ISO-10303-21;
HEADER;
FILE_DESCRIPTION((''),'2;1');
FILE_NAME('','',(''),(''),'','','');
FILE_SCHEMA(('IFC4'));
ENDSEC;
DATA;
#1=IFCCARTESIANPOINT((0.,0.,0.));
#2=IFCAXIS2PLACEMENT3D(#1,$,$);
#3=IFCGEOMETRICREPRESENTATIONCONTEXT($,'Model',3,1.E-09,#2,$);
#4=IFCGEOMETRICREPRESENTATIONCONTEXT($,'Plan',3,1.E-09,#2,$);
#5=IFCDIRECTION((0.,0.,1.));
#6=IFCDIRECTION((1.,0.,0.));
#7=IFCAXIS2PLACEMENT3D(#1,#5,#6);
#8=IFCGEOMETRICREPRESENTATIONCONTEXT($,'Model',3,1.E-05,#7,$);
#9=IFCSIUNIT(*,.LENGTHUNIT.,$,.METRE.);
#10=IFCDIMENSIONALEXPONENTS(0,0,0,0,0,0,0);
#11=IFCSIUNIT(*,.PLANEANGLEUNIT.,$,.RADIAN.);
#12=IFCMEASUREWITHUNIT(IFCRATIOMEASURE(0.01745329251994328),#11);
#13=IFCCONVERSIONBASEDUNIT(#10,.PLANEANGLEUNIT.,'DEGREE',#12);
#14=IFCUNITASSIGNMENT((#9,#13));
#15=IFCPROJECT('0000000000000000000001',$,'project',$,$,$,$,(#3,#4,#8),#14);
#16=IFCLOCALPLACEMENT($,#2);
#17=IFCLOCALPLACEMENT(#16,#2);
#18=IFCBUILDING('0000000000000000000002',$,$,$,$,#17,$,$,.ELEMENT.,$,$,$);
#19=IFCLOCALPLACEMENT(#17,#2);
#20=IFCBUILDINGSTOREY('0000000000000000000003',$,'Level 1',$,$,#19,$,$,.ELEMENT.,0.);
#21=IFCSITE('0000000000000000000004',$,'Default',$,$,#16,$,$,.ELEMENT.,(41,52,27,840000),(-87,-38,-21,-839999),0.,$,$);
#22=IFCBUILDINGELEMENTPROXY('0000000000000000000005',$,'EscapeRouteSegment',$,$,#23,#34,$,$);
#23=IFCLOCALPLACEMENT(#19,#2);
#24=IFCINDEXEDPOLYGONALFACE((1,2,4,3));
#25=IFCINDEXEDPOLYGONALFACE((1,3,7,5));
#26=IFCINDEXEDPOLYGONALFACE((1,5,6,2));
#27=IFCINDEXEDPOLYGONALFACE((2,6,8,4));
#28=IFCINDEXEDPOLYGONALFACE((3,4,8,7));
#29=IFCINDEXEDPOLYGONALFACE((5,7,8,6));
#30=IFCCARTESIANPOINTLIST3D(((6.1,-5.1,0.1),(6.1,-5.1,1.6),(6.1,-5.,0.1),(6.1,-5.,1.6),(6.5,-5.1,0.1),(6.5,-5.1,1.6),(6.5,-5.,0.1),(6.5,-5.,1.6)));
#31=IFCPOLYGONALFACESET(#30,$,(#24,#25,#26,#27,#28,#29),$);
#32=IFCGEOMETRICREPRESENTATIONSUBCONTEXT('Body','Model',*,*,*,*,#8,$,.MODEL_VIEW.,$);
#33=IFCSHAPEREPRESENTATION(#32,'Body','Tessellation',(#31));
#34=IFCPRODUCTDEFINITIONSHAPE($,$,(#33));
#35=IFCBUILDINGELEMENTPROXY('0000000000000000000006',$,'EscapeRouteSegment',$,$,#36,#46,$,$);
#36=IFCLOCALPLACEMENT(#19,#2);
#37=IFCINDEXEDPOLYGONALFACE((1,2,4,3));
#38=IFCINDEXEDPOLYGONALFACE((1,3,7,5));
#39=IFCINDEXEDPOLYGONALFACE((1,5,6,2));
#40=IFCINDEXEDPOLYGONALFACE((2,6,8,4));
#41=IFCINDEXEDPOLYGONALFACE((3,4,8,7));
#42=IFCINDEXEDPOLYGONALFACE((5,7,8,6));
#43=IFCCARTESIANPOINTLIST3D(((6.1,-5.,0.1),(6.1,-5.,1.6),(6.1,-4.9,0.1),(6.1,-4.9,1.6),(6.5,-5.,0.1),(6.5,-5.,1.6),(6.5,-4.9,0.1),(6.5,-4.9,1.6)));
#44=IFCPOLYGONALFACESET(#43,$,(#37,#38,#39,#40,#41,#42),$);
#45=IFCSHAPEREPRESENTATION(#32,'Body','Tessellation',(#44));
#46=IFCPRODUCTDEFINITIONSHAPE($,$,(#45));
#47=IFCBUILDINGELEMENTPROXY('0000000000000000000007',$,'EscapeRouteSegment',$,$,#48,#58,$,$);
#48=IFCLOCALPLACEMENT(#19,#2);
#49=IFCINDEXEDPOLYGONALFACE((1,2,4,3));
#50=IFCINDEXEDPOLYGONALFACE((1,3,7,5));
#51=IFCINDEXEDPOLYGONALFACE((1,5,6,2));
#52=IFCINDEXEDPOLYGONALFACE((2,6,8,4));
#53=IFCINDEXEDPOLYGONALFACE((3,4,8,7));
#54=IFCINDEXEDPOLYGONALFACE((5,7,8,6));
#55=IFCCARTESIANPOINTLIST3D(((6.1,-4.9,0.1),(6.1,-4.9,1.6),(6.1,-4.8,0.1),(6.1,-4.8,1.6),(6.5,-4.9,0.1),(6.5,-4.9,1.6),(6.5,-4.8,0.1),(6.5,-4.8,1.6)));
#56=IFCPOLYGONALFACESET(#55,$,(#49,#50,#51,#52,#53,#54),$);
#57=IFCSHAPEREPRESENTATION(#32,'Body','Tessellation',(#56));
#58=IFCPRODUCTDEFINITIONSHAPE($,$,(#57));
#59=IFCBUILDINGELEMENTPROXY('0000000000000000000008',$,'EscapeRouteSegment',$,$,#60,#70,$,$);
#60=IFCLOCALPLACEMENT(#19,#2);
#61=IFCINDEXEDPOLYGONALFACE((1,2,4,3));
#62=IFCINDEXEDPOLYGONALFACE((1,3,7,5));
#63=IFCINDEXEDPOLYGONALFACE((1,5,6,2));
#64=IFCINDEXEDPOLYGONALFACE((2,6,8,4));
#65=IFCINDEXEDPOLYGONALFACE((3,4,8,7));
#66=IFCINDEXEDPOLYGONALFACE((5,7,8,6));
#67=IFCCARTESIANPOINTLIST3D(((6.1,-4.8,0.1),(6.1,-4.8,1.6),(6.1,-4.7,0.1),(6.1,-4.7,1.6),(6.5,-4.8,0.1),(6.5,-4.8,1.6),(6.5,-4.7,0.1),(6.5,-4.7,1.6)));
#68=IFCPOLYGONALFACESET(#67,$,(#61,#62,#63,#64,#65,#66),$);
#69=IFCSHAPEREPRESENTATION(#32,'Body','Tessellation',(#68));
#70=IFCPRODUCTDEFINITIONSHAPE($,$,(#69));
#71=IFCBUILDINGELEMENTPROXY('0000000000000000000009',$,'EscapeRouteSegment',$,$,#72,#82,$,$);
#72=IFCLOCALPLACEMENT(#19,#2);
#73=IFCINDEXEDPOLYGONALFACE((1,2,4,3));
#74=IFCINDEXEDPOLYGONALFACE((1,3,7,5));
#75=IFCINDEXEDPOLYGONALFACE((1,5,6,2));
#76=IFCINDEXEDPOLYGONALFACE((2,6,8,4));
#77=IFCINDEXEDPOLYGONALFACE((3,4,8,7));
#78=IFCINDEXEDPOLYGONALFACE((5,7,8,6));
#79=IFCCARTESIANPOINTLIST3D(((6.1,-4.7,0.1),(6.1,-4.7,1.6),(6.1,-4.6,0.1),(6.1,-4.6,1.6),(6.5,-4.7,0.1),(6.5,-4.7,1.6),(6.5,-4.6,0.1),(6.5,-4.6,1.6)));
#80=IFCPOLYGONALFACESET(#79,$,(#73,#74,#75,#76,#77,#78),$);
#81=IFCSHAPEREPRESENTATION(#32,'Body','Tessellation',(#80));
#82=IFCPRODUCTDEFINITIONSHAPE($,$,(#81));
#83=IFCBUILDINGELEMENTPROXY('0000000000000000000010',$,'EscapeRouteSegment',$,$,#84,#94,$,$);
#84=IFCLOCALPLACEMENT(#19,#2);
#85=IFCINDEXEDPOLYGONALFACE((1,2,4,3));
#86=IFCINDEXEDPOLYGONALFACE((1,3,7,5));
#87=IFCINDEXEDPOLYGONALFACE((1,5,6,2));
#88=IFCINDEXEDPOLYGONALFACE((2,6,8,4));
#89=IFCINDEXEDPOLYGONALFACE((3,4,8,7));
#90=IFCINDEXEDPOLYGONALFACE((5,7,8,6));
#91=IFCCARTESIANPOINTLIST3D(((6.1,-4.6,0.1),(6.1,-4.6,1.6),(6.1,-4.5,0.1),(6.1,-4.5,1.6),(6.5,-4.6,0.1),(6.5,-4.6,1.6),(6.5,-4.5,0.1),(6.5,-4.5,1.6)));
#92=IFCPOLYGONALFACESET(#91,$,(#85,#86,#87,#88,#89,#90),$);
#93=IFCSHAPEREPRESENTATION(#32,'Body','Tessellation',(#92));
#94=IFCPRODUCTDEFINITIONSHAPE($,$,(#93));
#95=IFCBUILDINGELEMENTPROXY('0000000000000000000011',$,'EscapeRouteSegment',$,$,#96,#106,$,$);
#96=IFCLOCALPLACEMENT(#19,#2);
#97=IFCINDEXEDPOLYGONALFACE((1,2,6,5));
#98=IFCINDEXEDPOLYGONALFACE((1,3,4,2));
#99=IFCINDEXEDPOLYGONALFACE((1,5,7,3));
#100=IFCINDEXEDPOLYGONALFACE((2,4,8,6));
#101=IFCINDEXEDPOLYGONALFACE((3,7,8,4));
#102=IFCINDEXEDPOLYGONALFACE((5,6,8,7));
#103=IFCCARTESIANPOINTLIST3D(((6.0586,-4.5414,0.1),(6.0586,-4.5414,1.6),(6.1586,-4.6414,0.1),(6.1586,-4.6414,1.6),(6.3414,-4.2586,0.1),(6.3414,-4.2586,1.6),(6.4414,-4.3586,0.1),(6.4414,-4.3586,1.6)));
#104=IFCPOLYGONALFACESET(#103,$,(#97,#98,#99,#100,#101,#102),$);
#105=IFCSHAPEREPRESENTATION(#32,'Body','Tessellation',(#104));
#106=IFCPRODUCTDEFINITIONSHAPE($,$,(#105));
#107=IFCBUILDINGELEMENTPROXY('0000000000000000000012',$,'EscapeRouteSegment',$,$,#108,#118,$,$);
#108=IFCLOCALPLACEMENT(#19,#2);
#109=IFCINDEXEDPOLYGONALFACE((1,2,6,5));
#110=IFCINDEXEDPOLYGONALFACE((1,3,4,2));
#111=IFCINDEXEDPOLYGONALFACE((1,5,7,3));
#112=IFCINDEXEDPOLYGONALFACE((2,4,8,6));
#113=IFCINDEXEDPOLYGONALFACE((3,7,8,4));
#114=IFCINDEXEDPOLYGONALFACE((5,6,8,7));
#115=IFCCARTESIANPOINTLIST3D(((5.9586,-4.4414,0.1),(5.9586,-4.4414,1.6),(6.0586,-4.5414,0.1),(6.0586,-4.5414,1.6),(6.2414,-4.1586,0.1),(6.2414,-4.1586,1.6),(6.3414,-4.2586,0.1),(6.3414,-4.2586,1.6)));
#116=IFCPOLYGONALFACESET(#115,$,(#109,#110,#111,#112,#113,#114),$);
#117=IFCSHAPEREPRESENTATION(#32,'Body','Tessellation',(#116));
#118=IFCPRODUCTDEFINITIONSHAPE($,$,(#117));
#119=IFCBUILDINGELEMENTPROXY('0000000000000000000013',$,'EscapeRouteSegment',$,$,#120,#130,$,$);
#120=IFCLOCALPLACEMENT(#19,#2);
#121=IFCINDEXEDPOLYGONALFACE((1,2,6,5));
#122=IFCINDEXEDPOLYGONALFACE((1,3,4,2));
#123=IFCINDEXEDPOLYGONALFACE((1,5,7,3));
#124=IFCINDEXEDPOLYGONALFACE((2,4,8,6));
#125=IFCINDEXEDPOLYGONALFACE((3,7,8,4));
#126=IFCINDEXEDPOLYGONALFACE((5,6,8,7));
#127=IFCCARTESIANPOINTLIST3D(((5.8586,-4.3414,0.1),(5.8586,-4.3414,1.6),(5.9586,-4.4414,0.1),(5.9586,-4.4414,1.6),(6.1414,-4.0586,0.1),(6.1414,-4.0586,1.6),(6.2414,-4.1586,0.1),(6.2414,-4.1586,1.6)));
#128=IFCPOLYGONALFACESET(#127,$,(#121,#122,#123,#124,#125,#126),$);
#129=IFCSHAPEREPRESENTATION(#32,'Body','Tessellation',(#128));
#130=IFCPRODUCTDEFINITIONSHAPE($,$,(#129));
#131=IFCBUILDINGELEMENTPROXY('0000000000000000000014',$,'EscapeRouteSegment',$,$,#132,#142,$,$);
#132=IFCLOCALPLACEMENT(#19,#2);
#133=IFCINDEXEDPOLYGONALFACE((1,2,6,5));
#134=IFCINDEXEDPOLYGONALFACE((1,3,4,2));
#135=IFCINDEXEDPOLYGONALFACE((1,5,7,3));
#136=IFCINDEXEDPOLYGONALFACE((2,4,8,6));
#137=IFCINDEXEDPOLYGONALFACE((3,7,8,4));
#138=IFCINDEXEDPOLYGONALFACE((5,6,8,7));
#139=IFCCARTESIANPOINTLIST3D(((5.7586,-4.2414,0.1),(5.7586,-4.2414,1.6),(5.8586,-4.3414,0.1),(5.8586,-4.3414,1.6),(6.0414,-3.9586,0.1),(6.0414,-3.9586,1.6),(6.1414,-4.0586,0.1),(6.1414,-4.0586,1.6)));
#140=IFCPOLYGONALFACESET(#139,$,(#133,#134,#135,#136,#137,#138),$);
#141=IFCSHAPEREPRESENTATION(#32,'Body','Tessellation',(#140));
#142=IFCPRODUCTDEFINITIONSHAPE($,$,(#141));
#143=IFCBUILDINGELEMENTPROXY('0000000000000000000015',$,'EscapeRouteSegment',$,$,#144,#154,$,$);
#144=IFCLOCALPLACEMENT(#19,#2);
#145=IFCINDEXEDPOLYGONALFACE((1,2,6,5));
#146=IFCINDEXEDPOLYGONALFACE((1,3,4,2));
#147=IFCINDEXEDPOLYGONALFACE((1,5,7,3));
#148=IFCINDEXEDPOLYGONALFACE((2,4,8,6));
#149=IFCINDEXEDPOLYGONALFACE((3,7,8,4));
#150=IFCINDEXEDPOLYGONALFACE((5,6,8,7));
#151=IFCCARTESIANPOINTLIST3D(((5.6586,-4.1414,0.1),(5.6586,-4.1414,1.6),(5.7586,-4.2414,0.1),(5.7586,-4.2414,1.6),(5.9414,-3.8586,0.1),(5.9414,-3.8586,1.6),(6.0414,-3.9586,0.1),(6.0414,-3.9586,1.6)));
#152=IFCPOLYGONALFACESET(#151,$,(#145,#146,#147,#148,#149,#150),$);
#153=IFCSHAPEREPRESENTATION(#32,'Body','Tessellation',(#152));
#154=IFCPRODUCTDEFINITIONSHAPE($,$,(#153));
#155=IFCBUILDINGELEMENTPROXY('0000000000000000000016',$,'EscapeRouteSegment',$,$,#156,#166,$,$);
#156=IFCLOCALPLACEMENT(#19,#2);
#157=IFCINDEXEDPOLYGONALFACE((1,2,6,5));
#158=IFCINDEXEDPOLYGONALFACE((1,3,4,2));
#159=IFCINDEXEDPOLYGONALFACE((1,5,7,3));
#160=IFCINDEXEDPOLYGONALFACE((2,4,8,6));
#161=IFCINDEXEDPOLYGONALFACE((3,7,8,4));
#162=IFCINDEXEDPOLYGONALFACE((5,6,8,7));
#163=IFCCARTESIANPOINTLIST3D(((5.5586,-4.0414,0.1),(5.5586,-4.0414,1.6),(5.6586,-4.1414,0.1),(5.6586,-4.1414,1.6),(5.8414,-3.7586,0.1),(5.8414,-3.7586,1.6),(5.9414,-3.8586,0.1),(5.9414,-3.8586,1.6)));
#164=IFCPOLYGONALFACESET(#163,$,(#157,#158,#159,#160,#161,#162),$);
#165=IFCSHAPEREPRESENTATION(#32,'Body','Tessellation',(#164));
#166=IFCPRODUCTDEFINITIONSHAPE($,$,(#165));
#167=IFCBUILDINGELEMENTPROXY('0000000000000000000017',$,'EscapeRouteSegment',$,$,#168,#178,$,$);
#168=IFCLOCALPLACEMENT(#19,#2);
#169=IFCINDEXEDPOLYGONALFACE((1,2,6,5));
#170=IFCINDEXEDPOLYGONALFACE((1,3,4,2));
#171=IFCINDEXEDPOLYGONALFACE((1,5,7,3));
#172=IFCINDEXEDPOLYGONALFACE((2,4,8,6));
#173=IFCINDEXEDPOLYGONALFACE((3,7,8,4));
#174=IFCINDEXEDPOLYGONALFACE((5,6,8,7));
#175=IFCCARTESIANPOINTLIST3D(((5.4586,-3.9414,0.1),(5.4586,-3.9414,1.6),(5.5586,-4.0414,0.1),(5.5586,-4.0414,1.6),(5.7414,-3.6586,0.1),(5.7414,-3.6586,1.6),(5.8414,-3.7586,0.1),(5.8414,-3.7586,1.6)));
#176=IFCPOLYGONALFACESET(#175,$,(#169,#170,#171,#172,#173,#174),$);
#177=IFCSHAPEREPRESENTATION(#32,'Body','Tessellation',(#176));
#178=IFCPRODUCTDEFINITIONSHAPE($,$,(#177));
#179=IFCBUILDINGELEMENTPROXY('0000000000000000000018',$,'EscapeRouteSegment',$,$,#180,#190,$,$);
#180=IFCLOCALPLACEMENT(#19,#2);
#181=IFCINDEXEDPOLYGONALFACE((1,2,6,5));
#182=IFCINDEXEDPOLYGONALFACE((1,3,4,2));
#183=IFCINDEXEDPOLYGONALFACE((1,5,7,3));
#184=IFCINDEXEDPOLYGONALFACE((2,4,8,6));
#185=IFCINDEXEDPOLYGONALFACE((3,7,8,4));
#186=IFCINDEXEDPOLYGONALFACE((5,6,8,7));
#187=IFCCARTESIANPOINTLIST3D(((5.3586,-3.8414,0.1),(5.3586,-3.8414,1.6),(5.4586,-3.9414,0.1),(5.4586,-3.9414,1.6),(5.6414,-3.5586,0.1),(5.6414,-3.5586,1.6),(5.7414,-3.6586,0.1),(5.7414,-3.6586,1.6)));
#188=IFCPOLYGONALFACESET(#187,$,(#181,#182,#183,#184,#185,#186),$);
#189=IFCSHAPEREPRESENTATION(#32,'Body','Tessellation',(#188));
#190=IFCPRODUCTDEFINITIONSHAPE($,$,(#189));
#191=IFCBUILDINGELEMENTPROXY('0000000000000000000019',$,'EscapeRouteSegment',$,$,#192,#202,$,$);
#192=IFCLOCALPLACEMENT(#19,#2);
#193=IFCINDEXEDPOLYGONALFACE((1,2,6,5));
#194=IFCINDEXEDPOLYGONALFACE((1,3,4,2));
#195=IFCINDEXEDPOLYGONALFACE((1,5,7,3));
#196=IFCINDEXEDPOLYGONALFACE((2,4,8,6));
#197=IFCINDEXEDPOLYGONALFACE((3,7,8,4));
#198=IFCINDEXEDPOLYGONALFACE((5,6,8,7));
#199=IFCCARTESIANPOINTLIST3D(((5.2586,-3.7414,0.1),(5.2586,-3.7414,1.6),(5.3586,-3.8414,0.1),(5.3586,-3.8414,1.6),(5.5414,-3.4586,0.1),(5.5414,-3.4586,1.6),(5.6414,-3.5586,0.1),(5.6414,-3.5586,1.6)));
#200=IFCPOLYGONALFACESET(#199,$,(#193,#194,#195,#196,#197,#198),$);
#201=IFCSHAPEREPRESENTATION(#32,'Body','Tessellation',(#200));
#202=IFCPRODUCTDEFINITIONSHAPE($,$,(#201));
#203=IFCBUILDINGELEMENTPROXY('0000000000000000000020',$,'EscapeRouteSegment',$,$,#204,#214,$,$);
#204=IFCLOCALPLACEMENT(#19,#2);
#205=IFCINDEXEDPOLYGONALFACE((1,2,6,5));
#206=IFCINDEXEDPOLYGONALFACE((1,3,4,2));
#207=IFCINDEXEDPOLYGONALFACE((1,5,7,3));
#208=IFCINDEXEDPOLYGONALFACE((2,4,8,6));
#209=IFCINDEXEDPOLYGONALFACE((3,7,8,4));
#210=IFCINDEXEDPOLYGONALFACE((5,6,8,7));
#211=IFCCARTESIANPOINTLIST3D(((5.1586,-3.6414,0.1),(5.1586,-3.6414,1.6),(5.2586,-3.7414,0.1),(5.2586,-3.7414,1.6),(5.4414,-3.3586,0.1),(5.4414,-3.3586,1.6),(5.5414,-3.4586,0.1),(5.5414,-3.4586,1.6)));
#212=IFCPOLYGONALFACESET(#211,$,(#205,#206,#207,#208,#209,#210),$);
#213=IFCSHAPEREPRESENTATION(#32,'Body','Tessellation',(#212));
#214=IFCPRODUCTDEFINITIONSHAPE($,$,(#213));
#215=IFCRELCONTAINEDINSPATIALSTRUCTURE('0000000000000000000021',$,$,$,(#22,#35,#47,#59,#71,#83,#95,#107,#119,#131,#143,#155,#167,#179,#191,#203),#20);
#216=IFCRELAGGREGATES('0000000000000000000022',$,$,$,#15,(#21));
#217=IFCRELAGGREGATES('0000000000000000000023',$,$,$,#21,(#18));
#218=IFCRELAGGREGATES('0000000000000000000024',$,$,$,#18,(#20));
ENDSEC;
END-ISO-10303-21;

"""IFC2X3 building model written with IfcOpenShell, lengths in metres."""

from ifc_helpers import new_model, entity, si_unit, converted_unit, frame, origin, origin_with_axes, place, context, subcontext, project, spatial, polyline, outline, extrude, element, save


model = new_model("IFC2X3")

# Units and contexts
model_context_1 = context("Model", 3, precision=1e-09, world=origin())
plan_context = context("Plan", 3, precision=1e-09, world=origin())
model_context_2 = context("Model", 3, precision=1e-05, world=origin_with_axes())
body_context = subcontext(model_context_2, "Body", "Model", "MODEL_VIEW")
ifc_project = project(units=[si_unit("LENGTHUNIT", "METRE"), converted_unit("PLANEANGLEUNIT", "DEGREE", entity("IfcRatioMeasure", 0.01745329251994328), si_unit("PLANEANGLEUNIT", "RADIAN"), dimensions=[0, 0, 0, 0, 0, 0, 0])], contexts=[model_context_1, plan_context, model_context_2])

# Site, building, storey
site_placement = place(None, origin())
site = spatial("IfcSite", under=ifc_project, at=site_placement, Name="Default", CompositionType="ELEMENT", RefLatitude=(41, 52, 27, 840000), RefLongitude=(-87, -38, -21, -839999), RefElevation=0.0)
building_placement = place(site_placement, origin())
building = spatial("IfcBuilding", under=site, at=building_placement, CompositionType="ELEMENT")
storey_placement = place(building_placement, origin())
storey = spatial("IfcBuildingStorey", under=building, at=storey_placement, Name="Level 1", CompositionType="ELEMENT", Elevation=0.0)

# Building element proxies
for number, where, z_axis, x_axis, name in (
    (1, (6.3, -5.1, 0.1), (0.0, 0.0, 1.0), (0.0, 1.0, 0.0), "EscapeRouteSegment"),
    (2, (6.3, -5.0, 0.1), (0.0, 0.0, 1.0), (0.0, 1.0, 0.0), "EscapeRouteSegment"),
    (3, (6.3, -4.9, 0.1), (0.0, 0.0, 1.0), (0.0, 1.0, 0.0), "EscapeRouteSegment"),
):
    element("IfcBuildingElementProxy", number, at=place(storey_placement, frame(where, z_axis=z_axis, x_axis=x_axis)), inside=storey, Name=name, context=body_context, shape_type="SweptSolid", body=[
        extrude(outline(polyline([(0.0, -0.2), (0.0, 0.2), (0.1, 0.2), (0.1, -0.2), (0.0, -0.2)])), origin_with_axes(), (0.0, 0.0, 1.0), 1.5),
    ])
proxy_1_placement = place(storey_placement, frame((6.3, -4.8, 0.1), z_axis=(0.0, 0.0, 1.0), x_axis=(0.0, 1.0, 0.0)))
element("IfcBuildingElementProxy", 4, at=proxy_1_placement, inside=storey, Name="EscapeRouteSegment", context=body_context, shape_type="SweptSolid", body=[
    extrude(outline(polyline([(0.0, -0.2), (0.0, 0.2), (0.1, 0.2), (0.1, -0.2), (0.0, -0.2)])), origin_with_axes(), (0.0, 0.0, 1.0), 1.5),
])
for number, where, z_axis, x_axis, name in (
    (5, (6.3, -4.7, 0.1), (0.0, 0.0, 1.0), (0.0, 1.0, 0.0), "EscapeRouteSegment"),
    (6, (6.3, -4.6, 0.1), (0.0, 0.0, 1.0), (0.0, 1.0, 0.0), "EscapeRouteSegment"),
):
    element("IfcBuildingElementProxy", number, at=place(storey_placement, frame(where, z_axis=z_axis, x_axis=x_axis)), inside=storey, Name=name, context=body_context, shape_type="SweptSolid", body=[
        extrude(outline(polyline([(0.0, -0.2), (0.0, 0.2), (0.1, 0.2), (0.1, -0.2), (0.0, -0.2)])), origin_with_axes(), (0.0, 0.0, 1.0), 1.5),
    ])
proxy_2_placement = place(storey_placement, frame((6.3, -4.5, 0.1), z_axis=(0.0, 0.0, 1.0), x_axis=(-0.707108, 0.707105, 0.0)))
element("IfcBuildingElementProxy", 7, at=proxy_2_placement, inside=storey, Name="EscapeRouteSegment", context=body_context, shape_type="SweptSolid", body=[
    extrude(outline(polyline([(0.0, -0.2), (0.0, 0.2), (0.1414, 0.2), (0.1414, -0.2), (0.0, -0.2)])), origin_with_axes(), (0.0, 0.0, 1.0), 1.5),
])
proxy_3_placement = place(storey_placement, frame((6.2, -4.4, 0.1), z_axis=(0.0, 0.0, 1.0), x_axis=(-0.707107, 0.707107, 0.0)))
element("IfcBuildingElementProxy", 8, at=proxy_3_placement, inside=storey, Name="EscapeRouteSegment", context=body_context, shape_type="SweptSolid", body=[
    extrude(outline(polyline([(0.0, -0.2), (0.0, 0.2), (0.1414, 0.2), (0.1414, -0.2), (0.0, -0.2)])), origin_with_axes(), (0.0, 0.0, 1.0), 1.5),
])
proxy_4_placement = place(storey_placement, frame((6.1, -4.3, 0.1), z_axis=(0.0, 0.0, 1.0), x_axis=(-0.707105, 0.707108, 0.0)))
element("IfcBuildingElementProxy", 9, at=proxy_4_placement, inside=storey, Name="EscapeRouteSegment", context=body_context, shape_type="SweptSolid", body=[
    extrude(outline(polyline([(0.0, -0.2), (0.0, 0.2), (0.1414, 0.2), (0.1414, -0.2), (0.0, -0.2)])), origin_with_axes(), (0.0, 0.0, 1.0), 1.5),
])
for number, where, z_axis, x_axis, name in (
    (10, (6.0, -4.2, 0.1), (0.0, 0.0, 1.0), (-0.707107, 0.707107, 0.0), "EscapeRouteSegment"),
    (11, (5.9, -4.1, 0.1), (0.0, 0.0, 1.0), (-0.707107, 0.707107, 0.0), "EscapeRouteSegment"),
):
    element("IfcBuildingElementProxy", number, at=place(storey_placement, frame(where, z_axis=z_axis, x_axis=x_axis)), inside=storey, Name=name, context=body_context, shape_type="SweptSolid", body=[
        extrude(outline(polyline([(0.0, -0.2), (0.0, 0.2), (0.1414, 0.2), (0.1414, -0.2), (0.0, -0.2)])), origin_with_axes(), (0.0, 0.0, 1.0), 1.5),
    ])
proxy_5_placement = place(storey_placement, frame((5.8, -4.0, 0.1), z_axis=(0.0, 0.0, 1.0), x_axis=(-0.707108, 0.707105, 0.0)))
element("IfcBuildingElementProxy", 12, at=proxy_5_placement, inside=storey, Name="EscapeRouteSegment", context=body_context, shape_type="SweptSolid", body=[
    extrude(outline(polyline([(0.0, -0.2), (0.0, 0.2), (0.1414, 0.2), (0.1414, -0.2), (0.0, -0.2)])), origin_with_axes(), (0.0, 0.0, 1.0), 1.5),
])
proxy_6_placement = place(storey_placement, frame((5.7, -3.9, 0.1), z_axis=(0.0, 0.0, 1.0), x_axis=(-0.707106, 0.707108, 0.0)))
element("IfcBuildingElementProxy", 13, at=proxy_6_placement, inside=storey, Name="EscapeRouteSegment", context=body_context, shape_type="SweptSolid", body=[
    extrude(outline(polyline([(0.0, -0.2), (0.0, 0.2), (0.1414, 0.2), (0.1414, -0.2), (0.0, -0.2)])), origin_with_axes(), (0.0, 0.0, 1.0), 1.5),
])
proxy_7_placement = place(storey_placement, frame((5.6, -3.8, 0.1), z_axis=(0.0, 0.0, 1.0), x_axis=(-0.707107, 0.707107, 0.0)))
element("IfcBuildingElementProxy", 14, at=proxy_7_placement, inside=storey, Name="EscapeRouteSegment", context=body_context, shape_type="SweptSolid", body=[
    extrude(outline(polyline([(0.0, -0.2), (0.0, 0.2), (0.1414, 0.2), (0.1414, -0.2), (0.0, -0.2)])), origin_with_axes(), (0.0, 0.0, 1.0), 1.5),
])
proxy_8_placement = place(storey_placement, frame((5.5, -3.7, 0.1), z_axis=(0.0, 0.0, 1.0), x_axis=(-0.707106, 0.707108, 0.0)))
element("IfcBuildingElementProxy", 15, at=proxy_8_placement, inside=storey, Name="EscapeRouteSegment", context=body_context, shape_type="SweptSolid", body=[
    extrude(outline(polyline([(0.0, -0.2), (0.0, 0.2), (0.1414, 0.2), (0.1414, -0.2), (0.0, -0.2)])), origin_with_axes(), (0.0, 0.0, 1.0), 1.5),
])
proxy_9_placement = place(storey_placement, frame((5.4, -3.6, 0.1), z_axis=(0.0, 0.0, 1.0), x_axis=(-0.707107, 0.707107, 0.0)))
element("IfcBuildingElementProxy", 16, at=proxy_9_placement, inside=storey, Name="EscapeRouteSegment", context=body_context, shape_type="SweptSolid", body=[
    extrude(outline(polyline([(0.0, -0.2), (0.0, 0.2), (0.1414, 0.2), (0.1414, -0.2), (0.0, -0.2)])), origin_with_axes(), (0.0, 0.0, 1.0), 1.5),
])

save(model, "model.ifc")
